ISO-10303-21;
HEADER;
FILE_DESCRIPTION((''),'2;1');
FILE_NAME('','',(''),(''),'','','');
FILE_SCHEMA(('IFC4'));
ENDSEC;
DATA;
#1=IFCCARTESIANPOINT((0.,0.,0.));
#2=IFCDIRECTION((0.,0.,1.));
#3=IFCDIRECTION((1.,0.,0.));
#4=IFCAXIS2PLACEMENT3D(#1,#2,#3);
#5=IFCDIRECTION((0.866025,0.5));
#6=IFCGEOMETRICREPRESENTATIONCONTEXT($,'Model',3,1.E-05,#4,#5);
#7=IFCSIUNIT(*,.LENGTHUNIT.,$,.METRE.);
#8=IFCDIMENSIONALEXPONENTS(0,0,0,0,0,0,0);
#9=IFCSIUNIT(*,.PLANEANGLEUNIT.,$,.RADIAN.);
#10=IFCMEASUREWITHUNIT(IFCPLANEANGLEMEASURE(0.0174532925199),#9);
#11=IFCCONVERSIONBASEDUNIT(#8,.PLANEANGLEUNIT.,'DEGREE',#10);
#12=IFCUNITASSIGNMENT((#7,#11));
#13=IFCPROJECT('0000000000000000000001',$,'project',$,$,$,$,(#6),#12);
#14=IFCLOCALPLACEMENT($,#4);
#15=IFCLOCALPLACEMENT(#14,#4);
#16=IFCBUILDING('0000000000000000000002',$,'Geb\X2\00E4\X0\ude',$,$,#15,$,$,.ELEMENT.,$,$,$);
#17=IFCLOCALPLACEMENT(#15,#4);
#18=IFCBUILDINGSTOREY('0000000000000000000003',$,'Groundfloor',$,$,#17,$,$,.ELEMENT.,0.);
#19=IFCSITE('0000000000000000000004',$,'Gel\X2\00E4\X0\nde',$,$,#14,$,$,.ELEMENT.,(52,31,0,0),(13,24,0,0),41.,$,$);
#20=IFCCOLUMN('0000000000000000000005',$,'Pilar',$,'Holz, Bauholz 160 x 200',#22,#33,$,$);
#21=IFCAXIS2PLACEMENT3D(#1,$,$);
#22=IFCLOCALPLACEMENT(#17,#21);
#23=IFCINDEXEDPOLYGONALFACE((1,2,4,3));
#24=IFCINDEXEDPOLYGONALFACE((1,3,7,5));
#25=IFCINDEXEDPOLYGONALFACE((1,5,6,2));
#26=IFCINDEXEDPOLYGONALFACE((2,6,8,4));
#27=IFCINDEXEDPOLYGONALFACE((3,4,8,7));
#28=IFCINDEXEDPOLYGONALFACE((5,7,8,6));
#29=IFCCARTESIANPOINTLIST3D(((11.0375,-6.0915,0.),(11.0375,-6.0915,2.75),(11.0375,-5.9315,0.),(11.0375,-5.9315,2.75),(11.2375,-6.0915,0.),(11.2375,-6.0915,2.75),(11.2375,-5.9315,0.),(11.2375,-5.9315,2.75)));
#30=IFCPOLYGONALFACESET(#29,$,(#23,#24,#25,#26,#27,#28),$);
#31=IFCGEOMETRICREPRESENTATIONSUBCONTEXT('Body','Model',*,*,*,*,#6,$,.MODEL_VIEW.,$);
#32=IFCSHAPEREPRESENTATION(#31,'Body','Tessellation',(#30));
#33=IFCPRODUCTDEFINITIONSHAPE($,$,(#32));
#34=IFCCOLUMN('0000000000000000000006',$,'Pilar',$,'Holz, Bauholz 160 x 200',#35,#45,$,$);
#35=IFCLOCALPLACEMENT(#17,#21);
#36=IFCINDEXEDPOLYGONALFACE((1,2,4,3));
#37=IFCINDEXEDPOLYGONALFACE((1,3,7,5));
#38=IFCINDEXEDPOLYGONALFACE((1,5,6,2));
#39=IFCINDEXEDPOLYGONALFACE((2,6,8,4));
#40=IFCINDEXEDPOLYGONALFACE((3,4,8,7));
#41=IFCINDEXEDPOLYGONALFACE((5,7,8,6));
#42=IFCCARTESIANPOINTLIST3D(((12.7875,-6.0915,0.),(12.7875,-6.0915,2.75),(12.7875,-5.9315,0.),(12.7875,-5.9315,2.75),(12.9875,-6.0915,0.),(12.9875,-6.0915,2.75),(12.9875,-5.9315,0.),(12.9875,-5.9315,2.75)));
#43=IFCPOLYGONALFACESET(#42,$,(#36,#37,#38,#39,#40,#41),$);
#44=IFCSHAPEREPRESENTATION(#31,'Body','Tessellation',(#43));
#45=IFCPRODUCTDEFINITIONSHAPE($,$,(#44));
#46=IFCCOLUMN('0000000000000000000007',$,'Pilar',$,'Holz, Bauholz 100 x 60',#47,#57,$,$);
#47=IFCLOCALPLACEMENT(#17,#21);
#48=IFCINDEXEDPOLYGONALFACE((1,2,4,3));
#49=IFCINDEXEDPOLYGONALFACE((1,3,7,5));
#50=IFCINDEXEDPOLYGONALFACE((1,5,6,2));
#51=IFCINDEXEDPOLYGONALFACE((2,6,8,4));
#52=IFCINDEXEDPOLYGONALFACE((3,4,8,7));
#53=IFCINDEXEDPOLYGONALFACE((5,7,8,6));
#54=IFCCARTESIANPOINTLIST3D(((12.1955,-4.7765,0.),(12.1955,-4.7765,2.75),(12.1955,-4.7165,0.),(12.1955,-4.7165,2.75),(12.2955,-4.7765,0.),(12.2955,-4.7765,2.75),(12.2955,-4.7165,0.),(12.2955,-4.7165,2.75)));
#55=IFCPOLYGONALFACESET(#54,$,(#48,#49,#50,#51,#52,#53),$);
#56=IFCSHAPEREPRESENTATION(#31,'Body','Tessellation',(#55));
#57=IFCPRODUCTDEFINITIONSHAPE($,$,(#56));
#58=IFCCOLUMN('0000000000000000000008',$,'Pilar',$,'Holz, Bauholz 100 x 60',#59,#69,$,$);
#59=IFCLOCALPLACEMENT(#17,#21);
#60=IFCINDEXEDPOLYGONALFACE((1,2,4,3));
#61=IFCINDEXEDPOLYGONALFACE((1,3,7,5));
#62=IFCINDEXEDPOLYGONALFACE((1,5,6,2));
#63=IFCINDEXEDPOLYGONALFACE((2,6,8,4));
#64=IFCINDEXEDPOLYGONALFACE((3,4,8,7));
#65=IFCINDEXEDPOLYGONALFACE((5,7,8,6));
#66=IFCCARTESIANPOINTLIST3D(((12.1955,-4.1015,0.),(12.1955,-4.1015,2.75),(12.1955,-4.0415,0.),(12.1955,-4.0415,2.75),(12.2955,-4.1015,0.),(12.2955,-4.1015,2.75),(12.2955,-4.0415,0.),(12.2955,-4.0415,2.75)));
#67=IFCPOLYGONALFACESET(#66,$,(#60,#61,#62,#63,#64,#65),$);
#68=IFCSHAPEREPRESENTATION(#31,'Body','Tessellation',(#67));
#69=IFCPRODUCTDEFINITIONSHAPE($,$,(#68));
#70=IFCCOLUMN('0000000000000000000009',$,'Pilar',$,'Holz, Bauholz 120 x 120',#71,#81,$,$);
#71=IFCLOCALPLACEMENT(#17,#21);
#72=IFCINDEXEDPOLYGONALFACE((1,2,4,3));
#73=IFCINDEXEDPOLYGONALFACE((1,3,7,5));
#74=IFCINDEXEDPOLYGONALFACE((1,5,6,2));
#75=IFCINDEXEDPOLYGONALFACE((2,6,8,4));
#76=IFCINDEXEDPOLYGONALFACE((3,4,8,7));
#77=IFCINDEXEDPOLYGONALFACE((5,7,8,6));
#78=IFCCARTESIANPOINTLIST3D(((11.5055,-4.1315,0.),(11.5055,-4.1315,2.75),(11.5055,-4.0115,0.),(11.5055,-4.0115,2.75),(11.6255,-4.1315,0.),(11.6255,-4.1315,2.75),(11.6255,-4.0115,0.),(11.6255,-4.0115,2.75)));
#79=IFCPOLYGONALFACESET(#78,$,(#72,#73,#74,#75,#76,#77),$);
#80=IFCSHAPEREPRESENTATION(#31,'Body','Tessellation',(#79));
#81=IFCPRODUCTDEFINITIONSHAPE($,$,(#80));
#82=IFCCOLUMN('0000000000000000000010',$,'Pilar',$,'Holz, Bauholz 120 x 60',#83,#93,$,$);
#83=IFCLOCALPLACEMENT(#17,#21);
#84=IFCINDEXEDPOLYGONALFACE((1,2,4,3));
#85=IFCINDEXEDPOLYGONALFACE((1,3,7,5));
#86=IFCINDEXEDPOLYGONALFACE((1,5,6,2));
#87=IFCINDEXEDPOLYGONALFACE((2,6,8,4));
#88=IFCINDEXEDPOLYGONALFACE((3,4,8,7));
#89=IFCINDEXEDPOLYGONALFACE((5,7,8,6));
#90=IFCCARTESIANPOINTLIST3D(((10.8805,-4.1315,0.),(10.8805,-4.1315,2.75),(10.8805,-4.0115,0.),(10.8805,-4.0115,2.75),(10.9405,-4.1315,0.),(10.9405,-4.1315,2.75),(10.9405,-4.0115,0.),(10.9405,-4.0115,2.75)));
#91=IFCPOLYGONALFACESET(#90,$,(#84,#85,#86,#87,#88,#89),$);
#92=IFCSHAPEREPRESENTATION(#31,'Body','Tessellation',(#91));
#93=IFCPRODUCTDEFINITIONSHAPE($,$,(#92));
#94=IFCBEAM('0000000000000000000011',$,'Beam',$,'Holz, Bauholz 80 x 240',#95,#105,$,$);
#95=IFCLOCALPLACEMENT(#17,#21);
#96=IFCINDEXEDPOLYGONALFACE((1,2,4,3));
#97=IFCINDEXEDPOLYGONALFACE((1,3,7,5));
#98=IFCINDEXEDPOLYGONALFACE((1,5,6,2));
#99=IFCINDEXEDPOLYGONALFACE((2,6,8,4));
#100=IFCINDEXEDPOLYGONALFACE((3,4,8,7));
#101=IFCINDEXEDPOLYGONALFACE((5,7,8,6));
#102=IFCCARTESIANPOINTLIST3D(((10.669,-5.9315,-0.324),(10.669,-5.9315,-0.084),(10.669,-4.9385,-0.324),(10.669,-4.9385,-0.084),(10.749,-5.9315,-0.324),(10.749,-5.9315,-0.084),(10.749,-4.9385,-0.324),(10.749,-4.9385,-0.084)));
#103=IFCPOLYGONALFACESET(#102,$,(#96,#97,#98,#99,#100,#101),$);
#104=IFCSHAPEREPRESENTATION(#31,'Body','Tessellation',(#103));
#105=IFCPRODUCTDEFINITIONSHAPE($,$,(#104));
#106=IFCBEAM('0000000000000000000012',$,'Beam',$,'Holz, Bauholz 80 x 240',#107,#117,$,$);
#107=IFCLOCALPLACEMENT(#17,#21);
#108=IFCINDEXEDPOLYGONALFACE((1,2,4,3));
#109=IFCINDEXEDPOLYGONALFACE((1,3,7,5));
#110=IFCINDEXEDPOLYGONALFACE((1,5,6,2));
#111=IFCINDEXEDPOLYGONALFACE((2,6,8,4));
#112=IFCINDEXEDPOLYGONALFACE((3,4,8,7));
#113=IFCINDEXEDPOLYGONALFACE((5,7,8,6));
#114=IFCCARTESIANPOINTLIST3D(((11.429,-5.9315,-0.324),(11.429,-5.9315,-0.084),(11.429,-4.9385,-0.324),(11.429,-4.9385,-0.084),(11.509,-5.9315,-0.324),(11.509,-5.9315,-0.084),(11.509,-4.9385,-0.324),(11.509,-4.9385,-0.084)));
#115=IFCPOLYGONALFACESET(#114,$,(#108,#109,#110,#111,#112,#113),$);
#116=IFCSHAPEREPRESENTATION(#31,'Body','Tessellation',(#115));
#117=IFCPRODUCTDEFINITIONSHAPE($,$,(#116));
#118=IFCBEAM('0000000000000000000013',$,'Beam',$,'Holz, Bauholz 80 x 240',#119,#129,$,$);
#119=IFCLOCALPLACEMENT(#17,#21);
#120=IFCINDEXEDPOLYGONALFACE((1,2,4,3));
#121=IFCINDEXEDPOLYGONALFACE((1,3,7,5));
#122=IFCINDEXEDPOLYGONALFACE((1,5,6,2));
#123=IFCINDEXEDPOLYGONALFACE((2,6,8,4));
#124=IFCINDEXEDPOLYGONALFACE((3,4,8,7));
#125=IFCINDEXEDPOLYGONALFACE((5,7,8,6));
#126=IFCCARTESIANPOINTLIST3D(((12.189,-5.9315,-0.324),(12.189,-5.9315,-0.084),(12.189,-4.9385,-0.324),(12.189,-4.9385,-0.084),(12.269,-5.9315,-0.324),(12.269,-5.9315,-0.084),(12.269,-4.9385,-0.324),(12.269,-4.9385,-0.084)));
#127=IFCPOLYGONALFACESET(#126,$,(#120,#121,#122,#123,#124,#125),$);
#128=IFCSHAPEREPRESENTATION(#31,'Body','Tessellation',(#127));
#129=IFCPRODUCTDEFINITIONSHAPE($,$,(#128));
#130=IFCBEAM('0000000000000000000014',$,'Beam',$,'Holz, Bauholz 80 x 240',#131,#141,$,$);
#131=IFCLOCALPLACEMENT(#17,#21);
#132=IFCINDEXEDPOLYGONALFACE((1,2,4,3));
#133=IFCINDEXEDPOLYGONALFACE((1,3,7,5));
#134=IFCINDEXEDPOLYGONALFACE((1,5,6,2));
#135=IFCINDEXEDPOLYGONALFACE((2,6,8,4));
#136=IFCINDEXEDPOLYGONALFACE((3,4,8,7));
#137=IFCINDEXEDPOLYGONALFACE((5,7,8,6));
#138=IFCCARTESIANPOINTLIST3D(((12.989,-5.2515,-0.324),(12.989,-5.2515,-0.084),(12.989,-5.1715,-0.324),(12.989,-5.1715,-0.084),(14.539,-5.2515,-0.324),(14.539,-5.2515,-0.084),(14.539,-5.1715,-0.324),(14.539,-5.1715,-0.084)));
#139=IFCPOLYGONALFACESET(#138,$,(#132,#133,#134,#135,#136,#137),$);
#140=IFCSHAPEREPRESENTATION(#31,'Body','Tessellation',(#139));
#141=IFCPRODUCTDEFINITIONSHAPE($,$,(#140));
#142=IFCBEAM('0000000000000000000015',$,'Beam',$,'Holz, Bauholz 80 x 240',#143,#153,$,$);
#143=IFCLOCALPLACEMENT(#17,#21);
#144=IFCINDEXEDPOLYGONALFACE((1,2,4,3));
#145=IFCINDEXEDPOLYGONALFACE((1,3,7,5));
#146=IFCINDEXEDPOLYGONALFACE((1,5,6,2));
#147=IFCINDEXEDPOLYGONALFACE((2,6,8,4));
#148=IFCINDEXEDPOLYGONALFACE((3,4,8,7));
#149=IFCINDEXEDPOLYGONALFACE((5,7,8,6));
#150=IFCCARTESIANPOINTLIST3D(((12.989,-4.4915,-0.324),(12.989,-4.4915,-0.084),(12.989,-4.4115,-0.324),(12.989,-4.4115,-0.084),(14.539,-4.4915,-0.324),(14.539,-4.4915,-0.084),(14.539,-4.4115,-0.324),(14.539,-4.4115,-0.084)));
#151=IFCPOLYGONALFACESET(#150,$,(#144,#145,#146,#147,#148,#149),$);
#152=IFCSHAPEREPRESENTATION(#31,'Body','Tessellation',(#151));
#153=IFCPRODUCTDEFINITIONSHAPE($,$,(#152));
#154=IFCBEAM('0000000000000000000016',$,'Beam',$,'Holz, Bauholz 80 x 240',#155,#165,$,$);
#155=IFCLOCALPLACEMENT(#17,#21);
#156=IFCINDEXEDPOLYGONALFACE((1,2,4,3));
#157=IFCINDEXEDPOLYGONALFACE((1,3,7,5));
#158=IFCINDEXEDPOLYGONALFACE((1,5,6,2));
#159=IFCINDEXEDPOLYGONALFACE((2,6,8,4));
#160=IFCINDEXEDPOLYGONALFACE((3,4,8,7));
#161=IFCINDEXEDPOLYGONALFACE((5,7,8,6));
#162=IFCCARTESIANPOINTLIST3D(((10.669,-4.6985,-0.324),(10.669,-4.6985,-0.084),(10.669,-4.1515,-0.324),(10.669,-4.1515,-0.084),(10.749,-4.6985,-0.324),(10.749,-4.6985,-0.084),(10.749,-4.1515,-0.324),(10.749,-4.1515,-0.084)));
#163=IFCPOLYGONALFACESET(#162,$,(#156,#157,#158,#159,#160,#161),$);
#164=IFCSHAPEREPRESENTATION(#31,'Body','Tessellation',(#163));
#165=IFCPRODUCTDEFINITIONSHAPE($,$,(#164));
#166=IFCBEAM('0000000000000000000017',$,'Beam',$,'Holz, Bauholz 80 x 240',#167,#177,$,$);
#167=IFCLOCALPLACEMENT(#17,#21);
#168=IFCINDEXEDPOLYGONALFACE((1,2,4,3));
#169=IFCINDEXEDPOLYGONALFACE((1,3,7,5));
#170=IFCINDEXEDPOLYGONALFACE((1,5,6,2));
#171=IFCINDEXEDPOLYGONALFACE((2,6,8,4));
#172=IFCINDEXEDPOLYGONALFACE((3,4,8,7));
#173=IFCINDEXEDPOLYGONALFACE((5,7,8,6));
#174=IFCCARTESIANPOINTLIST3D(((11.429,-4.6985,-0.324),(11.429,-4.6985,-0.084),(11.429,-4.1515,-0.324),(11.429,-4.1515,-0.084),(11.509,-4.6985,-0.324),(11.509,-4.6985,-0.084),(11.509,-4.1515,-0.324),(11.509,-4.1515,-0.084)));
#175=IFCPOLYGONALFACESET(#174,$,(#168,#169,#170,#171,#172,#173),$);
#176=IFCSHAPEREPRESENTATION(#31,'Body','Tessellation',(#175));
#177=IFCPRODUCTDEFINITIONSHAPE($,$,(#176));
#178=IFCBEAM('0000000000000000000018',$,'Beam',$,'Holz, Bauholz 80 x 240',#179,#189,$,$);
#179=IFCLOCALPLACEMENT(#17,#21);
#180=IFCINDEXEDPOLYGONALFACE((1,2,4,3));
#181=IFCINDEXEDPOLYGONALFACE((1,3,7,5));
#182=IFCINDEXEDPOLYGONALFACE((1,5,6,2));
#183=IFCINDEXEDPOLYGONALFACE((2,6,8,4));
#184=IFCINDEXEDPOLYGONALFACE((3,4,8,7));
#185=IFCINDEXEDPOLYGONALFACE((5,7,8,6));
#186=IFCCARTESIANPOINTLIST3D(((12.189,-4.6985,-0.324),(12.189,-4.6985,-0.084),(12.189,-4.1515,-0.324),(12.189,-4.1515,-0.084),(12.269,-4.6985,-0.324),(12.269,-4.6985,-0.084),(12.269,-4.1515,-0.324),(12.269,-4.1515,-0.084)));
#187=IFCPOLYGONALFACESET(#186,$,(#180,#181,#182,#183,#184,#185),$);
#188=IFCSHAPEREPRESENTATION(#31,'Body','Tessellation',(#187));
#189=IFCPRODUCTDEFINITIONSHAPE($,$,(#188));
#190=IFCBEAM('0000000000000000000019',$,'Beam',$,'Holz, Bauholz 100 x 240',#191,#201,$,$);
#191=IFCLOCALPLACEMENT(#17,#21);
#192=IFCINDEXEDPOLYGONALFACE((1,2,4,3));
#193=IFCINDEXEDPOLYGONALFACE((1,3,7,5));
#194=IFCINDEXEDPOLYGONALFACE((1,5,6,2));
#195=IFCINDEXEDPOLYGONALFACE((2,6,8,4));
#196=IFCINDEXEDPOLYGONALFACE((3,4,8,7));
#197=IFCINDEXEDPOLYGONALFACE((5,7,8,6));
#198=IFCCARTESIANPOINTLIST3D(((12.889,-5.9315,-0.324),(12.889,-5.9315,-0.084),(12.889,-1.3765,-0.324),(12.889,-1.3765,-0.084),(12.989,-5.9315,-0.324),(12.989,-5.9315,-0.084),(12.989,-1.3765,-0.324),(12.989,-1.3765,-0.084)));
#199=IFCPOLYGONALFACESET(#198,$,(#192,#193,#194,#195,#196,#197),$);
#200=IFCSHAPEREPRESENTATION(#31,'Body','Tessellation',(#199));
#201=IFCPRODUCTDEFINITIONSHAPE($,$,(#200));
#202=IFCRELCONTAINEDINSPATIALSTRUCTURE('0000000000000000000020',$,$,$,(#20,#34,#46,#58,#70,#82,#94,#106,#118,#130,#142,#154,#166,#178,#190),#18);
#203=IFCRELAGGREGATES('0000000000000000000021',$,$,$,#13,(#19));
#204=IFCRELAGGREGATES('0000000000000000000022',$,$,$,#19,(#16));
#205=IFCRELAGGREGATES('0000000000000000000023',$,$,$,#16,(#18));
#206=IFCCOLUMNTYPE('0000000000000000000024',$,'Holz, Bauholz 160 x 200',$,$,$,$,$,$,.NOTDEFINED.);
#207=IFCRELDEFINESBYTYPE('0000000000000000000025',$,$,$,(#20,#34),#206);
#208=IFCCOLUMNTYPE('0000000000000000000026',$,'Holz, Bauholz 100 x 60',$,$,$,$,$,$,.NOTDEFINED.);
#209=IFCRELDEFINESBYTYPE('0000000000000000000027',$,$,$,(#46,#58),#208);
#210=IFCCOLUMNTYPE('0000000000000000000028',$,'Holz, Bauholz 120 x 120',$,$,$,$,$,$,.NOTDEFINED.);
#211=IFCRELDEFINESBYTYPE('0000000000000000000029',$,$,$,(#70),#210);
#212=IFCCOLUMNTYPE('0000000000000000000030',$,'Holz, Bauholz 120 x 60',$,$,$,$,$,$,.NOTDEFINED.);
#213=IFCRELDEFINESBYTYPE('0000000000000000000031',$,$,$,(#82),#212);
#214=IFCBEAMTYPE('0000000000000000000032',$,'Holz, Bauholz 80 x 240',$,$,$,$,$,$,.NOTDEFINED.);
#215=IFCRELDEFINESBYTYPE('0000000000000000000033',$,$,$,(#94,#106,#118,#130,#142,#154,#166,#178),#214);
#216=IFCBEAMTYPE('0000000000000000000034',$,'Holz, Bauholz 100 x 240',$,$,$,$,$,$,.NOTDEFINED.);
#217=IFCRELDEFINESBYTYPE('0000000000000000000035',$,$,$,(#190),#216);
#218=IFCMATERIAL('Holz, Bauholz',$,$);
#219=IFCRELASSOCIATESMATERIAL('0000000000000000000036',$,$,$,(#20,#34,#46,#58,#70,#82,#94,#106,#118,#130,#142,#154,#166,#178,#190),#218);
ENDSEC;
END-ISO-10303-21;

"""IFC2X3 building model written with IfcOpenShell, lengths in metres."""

from ifc_helpers import new_model, entity, si_unit, converted_unit, direction, frame, frame_2d, origin_with_axes, origin_2d_with_axis, place, context, subcontext, project, spatial, rectangle, extrude, clip, halfspace, material, type_object, element, save


model = new_model("IFC2X3")

# Units and contexts
model_context = context("Model", 3, precision=1e-05, world=origin_with_axes(), true_north=direction((0.866025, 0.5)))
body_context = subcontext(model_context, "Body", "Model", "MODEL_VIEW")
ifc_project = project(units=[si_unit("LENGTHUNIT", "METRE"), converted_unit("PLANEANGLEUNIT", "DEGREE", entity("IfcPlaneAngleMeasure", 0.0174532925199), si_unit("PLANEANGLEUNIT", "RADIAN"), dimensions=[0, 0, 0, 0, 0, 0, 0])], contexts=[model_context])

# Site, building, storey
site_placement = place(None, origin_with_axes())
site = spatial("IfcSite", under=ifc_project, at=site_placement, Name="Gelände", CompositionType="ELEMENT", RefLatitude=(52, 31, 0, 0), RefLongitude=(13, 24, 0, 0), RefElevation=41.0)
building_placement = place(site_placement, origin_with_axes())
building = spatial("IfcBuilding", under=site, at=building_placement, Name="Gebäude", CompositionType="ELEMENT")
storey_placement = place(building_placement, origin_with_axes())
storey = spatial("IfcBuildingStorey", under=building, at=storey_placement, Name="Groundfloor", CompositionType="ELEMENT", Elevation=0.0)

# Columns
ifc_material_1 = material(Name="Holz, Bauholz")
column_type_1 = type_object("IfcColumnType", Name="Holz, Bauholz 160 x 200", PredefinedType="NOTDEFINED")
for number, where, z_axis, x_axis, name in (
    (1, (11.1375, -6.0115, 0.0), (0.0, 0.0, 1.0), (1.0, 0.0, 0.0), "Pilar"),
    (2, (12.8875, -6.0115, 0.0), (0.0, 0.0, 1.0), (1.0, 0.0, 0.0), "Pilar"),
):
    element("IfcColumn", number, at=place(storey_placement, frame(where, z_axis=z_axis, x_axis=x_axis)), inside=storey, type_object=column_type_1, material=ifc_material_1, Name=name, ObjectType="Holz, Bauholz 160 x 200", context=body_context, shape_type="Clipping", body=[
        clip(clip(extrude(rectangle(XDim=0.16, YDim=0.2, at=origin_2d_with_axis()), frame((0.0, 0.0, 0.0), z_axis=(0.0, 0.0, 1.0), x_axis=(0.0, 1.0, 0.0)), (0.0, 0.0, 1.0), 2.75), halfspace(frame((0.0, 0.0, 2.75), z_axis=(0.0, 0.0, -1.0), x_axis=(0.0, 1.0, 0.0)), True)), halfspace(frame((0.0, 0.0, 0.0), z_axis=(0.0, 0.0, 1.0), x_axis=(0.0, -1.0, 0.0)), True)),
    ])
column_type_2 = type_object("IfcColumnType", Name="Holz, Bauholz 100 x 60", PredefinedType="NOTDEFINED")
for number, where, z_axis, x_axis, name in (
    (3, (12.2455, -4.7465, 0.0), (0.0, 0.0, 1.0), (0.0, -1.0, 0.0), "Pilar"),
    (4, (12.2455, -4.0715, 0.0), (0.0, 0.0, 1.0), (0.0, -1.0, 0.0), "Pilar"),
):
    element("IfcColumn", number, at=place(storey_placement, frame(where, z_axis=z_axis, x_axis=x_axis)), inside=storey, type_object=column_type_2, material=ifc_material_1, Name=name, ObjectType="Holz, Bauholz 100 x 60", context=body_context, shape_type="Clipping", body=[
        clip(clip(extrude(rectangle(XDim=0.1, YDim=0.06, at=origin_2d_with_axis()), frame((0.0, 0.0, 0.0), z_axis=(0.0, 0.0, 1.0), x_axis=(0.0, 1.0, 0.0)), (0.0, 0.0, 1.0), 2.75), halfspace(frame((0.0, 0.0, 2.75), z_axis=(0.0, 0.0, -1.0), x_axis=(0.0, 1.0, 0.0)), True)), halfspace(frame((0.0, 0.0, 0.0), z_axis=(0.0, 0.0, 1.0), x_axis=(0.0, -1.0, 0.0)), True)),
    ])
column_type_3 = type_object("IfcColumnType", Name="Holz, Bauholz 120 x 120", PredefinedType="NOTDEFINED")
column_1_placement = place(storey_placement, frame((11.5655, -4.0715, 0.0), z_axis=(0.0, 0.0, 1.0), x_axis=(1.0, 0.0, 0.0)))
element("IfcColumn", 5, at=column_1_placement, inside=storey, type_object=column_type_3, material=ifc_material_1, Name="Pilar", ObjectType="Holz, Bauholz 120 x 120", context=body_context, shape_type="Clipping", body=[
    clip(clip(extrude(rectangle(XDim=0.12, YDim=0.12, at=origin_2d_with_axis()), frame((0.0, 0.0, 0.0), z_axis=(0.0, 0.0, 1.0), x_axis=(0.0, 1.0, 0.0)), (0.0, 0.0, 1.0), 2.75), halfspace(frame((0.0, 0.0, 2.75), z_axis=(0.0, 0.0, -1.0), x_axis=(0.0, 1.0, 0.0)), True)), halfspace(frame((0.0, 0.0, 0.0), z_axis=(0.0, 0.0, 1.0), x_axis=(0.0, -1.0, 0.0)), True)),
])
column_type_4 = type_object("IfcColumnType", Name="Holz, Bauholz 120 x 60", PredefinedType="NOTDEFINED")
column_2_placement = place(storey_placement, frame((10.9105, -4.0715, 0.0), z_axis=(0.0, 0.0, 1.0), x_axis=(1.0, 0.0, 0.0)))
element("IfcColumn", 6, at=column_2_placement, inside=storey, type_object=column_type_4, material=ifc_material_1, Name="Pilar", ObjectType="Holz, Bauholz 120 x 60", context=body_context, shape_type="Clipping", body=[
    clip(clip(extrude(rectangle(XDim=0.12, YDim=0.06, at=origin_2d_with_axis()), frame((0.0, 0.0, 0.0), z_axis=(0.0, 0.0, 1.0), x_axis=(0.0, 1.0, 0.0)), (0.0, 0.0, 1.0), 2.75), halfspace(frame((0.0, 0.0, 2.75), z_axis=(0.0, 0.0, -1.0), x_axis=(0.0, 1.0, 0.0)), True)), halfspace(frame((0.0, 0.0, 0.0), z_axis=(0.0, 0.0, 1.0), x_axis=(0.0, -1.0, 0.0)), True)),
])

# Beams
beam_type_1 = type_object("IfcBeamType", Name="Holz, Bauholz 80 x 240", PredefinedType="NOTDEFINED")
for number, where, z_axis, x_axis, name in (
    (7, (10.709, -5.9315, -0.084), (0.0, 0.0, 1.0), (1.0, 0.0, 0.0), "Beam"),
    (8, (11.469, -5.9315, -0.084), (0.0, 0.0, 1.0), (1.0, 0.0, 0.0), "Beam"),
    (9, (12.229, -5.9315, -0.084), (0.0, 0.0, 1.0), (1.0, 0.0, 0.0), "Beam"),
):
    element("IfcBeam", number, at=place(storey_placement, frame(where, z_axis=z_axis, x_axis=x_axis)), inside=storey, type_object=beam_type_1, material=ifc_material_1, Name=name, ObjectType="Holz, Bauholz 80 x 240", context=body_context, shape_type="SweptSolid", body=[
        extrude(rectangle(XDim=0.24, YDim=0.08, at=frame_2d((-0.12, 0.0), x_axis=(1.0, 0.0))), frame((0.0, 0.0, 0.0), z_axis=(0.0, 1.0, 0.0), x_axis=(0.0, 0.0, 1.0)), (0.0, 0.0, 1.0), 0.993),
    ])
for number, where, z_axis, x_axis, name in (
    (10, (14.539, -5.2115, -0.084), (0.0, 0.0, 1.0), (0.0, 1.0, 0.0), "Beam"),
    (11, (14.539, -4.4515, -0.084), (0.0, 0.0, 1.0), (0.0, 1.0, 0.0), "Beam"),
):
    element("IfcBeam", number, at=place(storey_placement, frame(where, z_axis=z_axis, x_axis=x_axis)), inside=storey, type_object=beam_type_1, material=ifc_material_1, Name=name, ObjectType="Holz, Bauholz 80 x 240", context=body_context, shape_type="SweptSolid", body=[
        extrude(rectangle(XDim=0.24, YDim=0.08, at=frame_2d((-0.12, 0.0), x_axis=(1.0, 0.0))), frame((0.0, 0.0, 0.0), z_axis=(0.0, 1.0, 0.0), x_axis=(0.0, 0.0, 1.0)), (0.0, 0.0, 1.0), 1.55),
    ])
for number, where, z_axis, x_axis, name in (
    (12, (10.709, -4.6985, -0.084), (0.0, 0.0, 1.0), (1.0, 0.0, 0.0), "Beam"),
    (13, (11.469, -4.6985, -0.084), (0.0, 0.0, 1.0), (1.0, 0.0, 0.0), "Beam"),
    (14, (12.229, -4.6985, -0.084), (0.0, 0.0, 1.0), (1.0, 0.0, 0.0), "Beam"),
):
    element("IfcBeam", number, at=place(storey_placement, frame(where, z_axis=z_axis, x_axis=x_axis)), inside=storey, type_object=beam_type_1, material=ifc_material_1, Name=name, ObjectType="Holz, Bauholz 80 x 240", context=body_context, shape_type="SweptSolid", body=[
        extrude(rectangle(XDim=0.24, YDim=0.08, at=frame_2d((-0.12, 0.0), x_axis=(1.0, 0.0))), frame((0.0, 0.0, 0.0), z_axis=(0.0, 1.0, 0.0), x_axis=(0.0, 0.0, 1.0)), (0.0, 0.0, 1.0), 0.547),
    ])
beam_type_2 = type_object("IfcBeamType", Name="Holz, Bauholz 100 x 240", PredefinedType="NOTDEFINED")
for number, where, z_axis, x_axis, name in (
    (15, (12.939, -5.9315, -0.084), (0.0, 0.0, 1.0), (1.0, 0.0, 0.0), "Beam"),
):
    element("IfcBeam", number, at=place(storey_placement, frame(where, z_axis=z_axis, x_axis=x_axis)), inside=storey, type_object=beam_type_2, material=ifc_material_1, Name=name, ObjectType="Holz, Bauholz 100 x 240", context=body_context, shape_type="SweptSolid", body=[
        extrude(rectangle(XDim=0.24, YDim=0.1, at=frame_2d((-0.12, 0.0), x_axis=(1.0, 0.0))), frame((0.0, 0.0, 0.0), z_axis=(0.0, 1.0, 0.0), x_axis=(0.0, 0.0, 1.0)), (0.0, 0.0, 1.0), 4.555),
    ])

save(model, "model.ifc")
